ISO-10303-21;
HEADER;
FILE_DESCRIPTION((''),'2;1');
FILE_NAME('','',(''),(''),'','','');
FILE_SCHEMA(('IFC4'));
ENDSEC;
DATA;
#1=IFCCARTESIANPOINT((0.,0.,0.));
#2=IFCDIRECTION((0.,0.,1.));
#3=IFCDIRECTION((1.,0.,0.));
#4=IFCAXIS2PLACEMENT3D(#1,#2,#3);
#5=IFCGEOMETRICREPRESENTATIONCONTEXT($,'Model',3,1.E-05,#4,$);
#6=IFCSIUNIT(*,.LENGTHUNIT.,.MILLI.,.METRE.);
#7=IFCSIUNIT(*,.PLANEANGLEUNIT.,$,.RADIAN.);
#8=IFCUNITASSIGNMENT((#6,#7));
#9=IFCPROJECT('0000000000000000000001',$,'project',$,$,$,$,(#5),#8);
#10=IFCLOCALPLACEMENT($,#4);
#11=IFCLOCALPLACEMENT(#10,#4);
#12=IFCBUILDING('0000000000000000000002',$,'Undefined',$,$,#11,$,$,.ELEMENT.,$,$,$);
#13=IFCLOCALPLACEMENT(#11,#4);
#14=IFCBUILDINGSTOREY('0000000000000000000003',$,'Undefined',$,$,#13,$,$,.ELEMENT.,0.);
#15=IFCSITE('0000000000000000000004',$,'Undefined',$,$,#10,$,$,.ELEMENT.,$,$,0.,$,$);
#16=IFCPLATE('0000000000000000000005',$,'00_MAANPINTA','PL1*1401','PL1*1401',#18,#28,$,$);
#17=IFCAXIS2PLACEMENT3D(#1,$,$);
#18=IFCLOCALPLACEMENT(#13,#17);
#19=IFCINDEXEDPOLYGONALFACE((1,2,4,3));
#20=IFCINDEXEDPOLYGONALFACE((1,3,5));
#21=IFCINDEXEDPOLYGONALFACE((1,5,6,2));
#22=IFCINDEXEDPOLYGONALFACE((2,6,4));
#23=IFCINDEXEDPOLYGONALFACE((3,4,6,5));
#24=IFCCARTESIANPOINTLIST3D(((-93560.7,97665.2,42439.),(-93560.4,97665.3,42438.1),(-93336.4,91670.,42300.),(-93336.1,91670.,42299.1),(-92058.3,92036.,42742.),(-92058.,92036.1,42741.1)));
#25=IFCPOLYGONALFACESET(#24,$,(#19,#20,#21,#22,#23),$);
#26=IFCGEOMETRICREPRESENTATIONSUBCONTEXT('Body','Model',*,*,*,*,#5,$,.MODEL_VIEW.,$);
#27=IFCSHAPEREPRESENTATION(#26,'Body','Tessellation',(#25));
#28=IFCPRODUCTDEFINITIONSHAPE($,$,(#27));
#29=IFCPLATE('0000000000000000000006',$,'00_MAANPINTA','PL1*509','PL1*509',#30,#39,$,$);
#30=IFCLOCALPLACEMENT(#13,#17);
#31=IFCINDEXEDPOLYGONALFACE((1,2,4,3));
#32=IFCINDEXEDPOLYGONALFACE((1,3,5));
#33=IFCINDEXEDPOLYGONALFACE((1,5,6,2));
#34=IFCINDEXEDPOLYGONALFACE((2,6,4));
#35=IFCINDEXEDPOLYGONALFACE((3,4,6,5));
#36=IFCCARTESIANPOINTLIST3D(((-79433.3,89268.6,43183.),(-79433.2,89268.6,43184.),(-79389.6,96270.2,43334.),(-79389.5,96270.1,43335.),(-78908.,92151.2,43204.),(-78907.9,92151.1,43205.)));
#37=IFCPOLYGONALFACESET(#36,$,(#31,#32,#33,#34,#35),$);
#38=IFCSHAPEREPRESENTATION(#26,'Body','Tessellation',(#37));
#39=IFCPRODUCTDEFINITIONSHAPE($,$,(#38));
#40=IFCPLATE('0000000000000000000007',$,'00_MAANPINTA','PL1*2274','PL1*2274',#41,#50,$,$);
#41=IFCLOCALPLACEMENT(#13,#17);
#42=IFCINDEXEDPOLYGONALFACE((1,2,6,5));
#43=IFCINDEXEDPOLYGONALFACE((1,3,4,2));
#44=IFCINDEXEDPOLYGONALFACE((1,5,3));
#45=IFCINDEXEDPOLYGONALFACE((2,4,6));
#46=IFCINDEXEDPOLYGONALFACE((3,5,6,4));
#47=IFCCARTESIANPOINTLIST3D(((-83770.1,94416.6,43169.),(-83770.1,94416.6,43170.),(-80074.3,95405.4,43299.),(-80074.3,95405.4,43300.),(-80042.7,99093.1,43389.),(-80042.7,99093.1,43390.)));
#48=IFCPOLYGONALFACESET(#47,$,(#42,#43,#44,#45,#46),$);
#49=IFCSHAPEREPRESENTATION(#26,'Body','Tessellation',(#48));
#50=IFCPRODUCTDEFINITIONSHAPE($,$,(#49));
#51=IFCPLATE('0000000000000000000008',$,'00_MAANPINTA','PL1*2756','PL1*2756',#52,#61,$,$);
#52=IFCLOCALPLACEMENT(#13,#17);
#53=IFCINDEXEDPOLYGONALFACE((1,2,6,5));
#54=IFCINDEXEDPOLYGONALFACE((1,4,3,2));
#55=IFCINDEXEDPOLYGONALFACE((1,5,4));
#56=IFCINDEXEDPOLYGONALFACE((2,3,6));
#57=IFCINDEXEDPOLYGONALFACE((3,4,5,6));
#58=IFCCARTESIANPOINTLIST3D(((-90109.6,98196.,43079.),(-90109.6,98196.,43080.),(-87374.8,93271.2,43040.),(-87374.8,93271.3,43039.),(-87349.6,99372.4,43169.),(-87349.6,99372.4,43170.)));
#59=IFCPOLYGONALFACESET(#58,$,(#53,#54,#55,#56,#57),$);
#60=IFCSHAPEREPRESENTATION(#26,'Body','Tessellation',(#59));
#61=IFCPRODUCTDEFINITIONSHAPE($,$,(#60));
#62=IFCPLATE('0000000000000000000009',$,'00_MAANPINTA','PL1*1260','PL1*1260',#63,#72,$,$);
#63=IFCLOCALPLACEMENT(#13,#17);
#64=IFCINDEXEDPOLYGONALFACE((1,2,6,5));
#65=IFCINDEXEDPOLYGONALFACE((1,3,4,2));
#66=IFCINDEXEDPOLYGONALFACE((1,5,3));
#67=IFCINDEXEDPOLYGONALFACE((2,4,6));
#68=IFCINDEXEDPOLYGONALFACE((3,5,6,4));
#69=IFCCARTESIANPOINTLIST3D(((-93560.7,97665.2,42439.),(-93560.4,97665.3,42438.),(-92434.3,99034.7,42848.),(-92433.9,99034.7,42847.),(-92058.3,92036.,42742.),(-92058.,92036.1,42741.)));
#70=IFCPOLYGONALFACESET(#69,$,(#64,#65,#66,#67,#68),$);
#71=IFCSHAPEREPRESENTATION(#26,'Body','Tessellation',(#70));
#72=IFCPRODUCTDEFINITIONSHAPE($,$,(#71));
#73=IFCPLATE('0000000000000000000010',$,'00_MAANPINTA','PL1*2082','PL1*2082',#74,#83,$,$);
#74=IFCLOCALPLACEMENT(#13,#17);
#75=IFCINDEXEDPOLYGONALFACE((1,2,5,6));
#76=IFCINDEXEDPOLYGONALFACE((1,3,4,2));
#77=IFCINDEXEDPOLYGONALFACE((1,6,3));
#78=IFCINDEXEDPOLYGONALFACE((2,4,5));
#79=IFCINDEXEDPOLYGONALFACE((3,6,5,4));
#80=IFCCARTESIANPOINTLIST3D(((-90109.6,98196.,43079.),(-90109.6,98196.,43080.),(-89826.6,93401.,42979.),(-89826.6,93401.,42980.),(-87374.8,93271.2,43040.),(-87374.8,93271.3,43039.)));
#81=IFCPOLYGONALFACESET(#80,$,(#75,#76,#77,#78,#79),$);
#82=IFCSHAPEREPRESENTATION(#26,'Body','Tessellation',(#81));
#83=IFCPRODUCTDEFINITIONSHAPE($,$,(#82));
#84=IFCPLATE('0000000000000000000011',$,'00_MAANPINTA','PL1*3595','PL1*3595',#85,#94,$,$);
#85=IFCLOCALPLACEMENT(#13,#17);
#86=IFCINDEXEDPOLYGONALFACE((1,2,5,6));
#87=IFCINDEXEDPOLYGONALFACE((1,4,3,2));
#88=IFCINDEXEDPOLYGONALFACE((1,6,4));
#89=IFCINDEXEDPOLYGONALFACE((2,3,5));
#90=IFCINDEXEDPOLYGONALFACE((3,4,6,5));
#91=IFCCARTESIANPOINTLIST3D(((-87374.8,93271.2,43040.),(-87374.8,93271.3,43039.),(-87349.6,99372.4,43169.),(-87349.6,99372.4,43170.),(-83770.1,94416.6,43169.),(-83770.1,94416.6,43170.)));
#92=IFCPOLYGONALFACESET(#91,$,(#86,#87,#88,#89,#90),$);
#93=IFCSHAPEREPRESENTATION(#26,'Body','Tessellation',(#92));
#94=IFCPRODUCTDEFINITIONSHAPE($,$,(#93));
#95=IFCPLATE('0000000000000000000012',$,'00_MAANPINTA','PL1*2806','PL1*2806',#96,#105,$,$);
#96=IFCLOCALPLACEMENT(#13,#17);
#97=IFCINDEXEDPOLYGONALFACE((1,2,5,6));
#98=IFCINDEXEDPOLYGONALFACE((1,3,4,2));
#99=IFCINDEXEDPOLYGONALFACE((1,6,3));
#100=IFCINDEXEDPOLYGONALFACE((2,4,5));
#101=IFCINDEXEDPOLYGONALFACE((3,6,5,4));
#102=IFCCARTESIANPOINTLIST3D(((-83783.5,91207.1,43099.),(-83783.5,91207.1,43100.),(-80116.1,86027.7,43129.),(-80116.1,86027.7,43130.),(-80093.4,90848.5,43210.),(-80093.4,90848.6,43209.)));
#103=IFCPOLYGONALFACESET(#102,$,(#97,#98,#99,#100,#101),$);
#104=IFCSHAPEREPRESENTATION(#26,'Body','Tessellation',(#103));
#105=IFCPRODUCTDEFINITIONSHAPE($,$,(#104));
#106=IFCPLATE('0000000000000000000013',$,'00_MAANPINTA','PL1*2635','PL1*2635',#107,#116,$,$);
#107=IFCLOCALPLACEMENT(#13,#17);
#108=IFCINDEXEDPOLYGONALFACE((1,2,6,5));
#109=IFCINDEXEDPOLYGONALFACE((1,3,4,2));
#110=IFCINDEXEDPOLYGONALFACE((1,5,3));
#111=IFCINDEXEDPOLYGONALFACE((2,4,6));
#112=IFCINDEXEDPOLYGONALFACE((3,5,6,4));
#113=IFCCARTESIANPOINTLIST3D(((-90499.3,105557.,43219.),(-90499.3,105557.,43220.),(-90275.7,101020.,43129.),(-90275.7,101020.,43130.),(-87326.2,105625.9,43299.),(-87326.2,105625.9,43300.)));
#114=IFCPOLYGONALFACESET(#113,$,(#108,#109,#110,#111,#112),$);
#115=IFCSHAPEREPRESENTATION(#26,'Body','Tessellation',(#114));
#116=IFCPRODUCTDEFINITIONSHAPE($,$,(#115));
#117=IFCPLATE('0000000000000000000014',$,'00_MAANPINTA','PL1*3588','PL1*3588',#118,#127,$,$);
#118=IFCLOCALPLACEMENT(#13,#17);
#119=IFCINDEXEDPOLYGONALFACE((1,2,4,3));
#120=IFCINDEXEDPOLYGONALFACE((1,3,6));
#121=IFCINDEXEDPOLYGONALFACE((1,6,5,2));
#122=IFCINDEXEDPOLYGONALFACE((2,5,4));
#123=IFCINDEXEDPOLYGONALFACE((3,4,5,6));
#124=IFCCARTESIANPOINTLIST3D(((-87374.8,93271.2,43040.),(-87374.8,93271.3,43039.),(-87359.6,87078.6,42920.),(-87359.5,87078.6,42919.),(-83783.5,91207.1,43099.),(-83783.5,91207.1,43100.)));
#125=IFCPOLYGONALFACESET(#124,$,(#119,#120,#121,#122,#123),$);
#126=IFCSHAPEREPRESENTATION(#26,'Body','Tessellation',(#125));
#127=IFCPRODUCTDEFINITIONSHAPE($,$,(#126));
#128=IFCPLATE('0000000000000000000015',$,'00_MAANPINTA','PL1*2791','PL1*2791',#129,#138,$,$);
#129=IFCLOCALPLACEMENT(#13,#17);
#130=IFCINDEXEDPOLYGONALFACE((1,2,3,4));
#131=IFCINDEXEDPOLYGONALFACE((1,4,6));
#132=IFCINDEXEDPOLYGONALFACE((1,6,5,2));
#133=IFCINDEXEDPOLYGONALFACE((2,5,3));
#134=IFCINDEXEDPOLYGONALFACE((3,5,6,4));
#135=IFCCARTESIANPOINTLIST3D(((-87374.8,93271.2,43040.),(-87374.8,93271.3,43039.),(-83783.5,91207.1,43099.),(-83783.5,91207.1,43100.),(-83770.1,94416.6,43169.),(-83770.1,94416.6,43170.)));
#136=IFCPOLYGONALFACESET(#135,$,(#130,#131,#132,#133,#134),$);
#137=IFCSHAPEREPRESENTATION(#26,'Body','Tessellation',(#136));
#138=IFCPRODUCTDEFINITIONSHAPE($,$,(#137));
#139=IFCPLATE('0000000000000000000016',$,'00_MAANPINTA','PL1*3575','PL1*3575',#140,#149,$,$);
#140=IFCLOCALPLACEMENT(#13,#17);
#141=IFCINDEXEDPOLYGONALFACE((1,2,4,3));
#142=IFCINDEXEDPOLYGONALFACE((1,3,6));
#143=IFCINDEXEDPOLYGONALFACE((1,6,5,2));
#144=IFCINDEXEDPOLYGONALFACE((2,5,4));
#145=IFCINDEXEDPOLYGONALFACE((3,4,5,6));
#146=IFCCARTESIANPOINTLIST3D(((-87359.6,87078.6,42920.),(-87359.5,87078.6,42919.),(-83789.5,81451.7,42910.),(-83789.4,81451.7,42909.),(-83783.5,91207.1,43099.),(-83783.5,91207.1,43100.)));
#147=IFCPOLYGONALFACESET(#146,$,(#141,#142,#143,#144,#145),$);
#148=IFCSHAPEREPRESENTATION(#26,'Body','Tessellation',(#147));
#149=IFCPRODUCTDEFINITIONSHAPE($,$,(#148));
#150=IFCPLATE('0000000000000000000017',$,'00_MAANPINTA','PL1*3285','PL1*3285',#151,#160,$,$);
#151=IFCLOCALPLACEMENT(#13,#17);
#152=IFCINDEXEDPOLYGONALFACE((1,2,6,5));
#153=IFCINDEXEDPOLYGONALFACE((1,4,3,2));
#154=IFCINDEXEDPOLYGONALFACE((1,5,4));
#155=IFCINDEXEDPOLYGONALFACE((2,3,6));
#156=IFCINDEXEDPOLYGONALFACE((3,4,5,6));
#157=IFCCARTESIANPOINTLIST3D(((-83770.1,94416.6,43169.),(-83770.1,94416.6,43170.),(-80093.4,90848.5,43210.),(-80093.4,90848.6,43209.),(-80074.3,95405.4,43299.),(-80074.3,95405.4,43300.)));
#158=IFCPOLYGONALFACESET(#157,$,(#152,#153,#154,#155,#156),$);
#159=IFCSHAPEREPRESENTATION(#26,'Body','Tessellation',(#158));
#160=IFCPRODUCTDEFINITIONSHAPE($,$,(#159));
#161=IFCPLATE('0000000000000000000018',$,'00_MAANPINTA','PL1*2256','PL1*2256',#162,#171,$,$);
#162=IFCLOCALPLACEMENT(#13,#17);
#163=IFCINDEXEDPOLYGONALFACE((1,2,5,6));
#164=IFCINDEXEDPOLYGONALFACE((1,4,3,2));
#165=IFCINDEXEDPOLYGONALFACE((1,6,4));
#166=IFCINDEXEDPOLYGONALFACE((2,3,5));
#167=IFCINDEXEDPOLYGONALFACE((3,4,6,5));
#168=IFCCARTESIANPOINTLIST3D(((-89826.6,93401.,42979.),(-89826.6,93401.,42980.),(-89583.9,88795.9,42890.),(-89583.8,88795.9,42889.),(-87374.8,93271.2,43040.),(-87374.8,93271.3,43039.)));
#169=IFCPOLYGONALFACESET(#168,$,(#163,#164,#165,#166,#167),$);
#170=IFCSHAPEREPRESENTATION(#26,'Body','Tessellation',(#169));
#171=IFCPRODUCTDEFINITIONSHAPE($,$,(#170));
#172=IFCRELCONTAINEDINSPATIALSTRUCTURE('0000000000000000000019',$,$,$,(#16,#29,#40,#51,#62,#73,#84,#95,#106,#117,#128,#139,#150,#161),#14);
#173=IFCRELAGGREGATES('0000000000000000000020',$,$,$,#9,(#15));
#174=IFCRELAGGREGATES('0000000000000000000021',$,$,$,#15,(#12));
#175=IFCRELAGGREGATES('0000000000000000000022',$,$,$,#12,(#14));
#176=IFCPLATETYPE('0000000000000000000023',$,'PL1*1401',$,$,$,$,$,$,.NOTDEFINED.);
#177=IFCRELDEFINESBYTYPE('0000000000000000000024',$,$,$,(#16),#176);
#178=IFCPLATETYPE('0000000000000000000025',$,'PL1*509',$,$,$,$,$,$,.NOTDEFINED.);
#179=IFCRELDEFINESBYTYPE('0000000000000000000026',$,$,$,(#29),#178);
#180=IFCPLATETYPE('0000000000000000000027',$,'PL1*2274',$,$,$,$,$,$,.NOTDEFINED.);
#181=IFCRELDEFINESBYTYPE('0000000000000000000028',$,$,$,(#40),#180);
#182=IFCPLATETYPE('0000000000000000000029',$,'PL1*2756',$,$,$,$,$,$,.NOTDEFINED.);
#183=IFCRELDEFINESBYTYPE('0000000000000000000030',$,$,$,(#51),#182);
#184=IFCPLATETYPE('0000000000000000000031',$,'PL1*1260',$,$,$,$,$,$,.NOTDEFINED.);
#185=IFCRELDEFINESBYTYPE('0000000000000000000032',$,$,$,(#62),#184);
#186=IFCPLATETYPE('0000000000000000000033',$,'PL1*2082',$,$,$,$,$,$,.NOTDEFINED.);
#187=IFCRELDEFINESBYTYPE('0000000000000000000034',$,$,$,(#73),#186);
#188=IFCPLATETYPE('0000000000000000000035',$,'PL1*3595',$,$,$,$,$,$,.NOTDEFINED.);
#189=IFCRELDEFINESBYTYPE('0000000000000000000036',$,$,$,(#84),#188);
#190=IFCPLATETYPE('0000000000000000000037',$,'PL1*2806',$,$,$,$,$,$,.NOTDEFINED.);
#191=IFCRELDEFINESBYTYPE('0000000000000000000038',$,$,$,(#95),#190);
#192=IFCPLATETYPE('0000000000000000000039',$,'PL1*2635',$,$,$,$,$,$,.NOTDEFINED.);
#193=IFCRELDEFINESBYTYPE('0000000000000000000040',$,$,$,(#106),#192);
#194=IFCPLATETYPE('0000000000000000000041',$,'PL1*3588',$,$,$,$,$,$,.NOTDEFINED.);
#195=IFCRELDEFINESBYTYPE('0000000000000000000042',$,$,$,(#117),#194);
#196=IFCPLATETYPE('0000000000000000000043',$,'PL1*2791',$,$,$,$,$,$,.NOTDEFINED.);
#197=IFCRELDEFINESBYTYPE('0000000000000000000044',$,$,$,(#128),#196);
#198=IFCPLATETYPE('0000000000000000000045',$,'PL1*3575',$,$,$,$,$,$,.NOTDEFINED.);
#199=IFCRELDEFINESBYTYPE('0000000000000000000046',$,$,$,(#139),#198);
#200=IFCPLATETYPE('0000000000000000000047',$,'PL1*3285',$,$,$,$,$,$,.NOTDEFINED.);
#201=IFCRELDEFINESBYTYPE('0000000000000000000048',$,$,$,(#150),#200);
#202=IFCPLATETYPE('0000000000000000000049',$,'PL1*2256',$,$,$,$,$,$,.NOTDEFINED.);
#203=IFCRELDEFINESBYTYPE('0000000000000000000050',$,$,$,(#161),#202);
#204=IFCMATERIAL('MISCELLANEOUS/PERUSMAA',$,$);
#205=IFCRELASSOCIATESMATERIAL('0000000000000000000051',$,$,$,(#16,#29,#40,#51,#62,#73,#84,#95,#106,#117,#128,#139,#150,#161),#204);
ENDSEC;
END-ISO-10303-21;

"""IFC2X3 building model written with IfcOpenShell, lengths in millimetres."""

from ifc_helpers import new_model, si_unit, frame, origin_with_axes, place, context, subcontext, project, spatial, polyline, outline, extrude, material, type_object, element, save


model = new_model("IFC2X3")

# Units and contexts
model_context = context("Model", 3, precision=1e-05, world=origin_with_axes())
body_context = subcontext(model_context, "Body", "Model", "MODEL_VIEW")
ifc_project = project(units=[si_unit("LENGTHUNIT", "METRE", prefix="MILLI"), si_unit("PLANEANGLEUNIT", "RADIAN")], contexts=[model_context])

# Site, building, storey
site_placement = place(None, origin_with_axes())
site = spatial("IfcSite", under=ifc_project, at=site_placement, Name="Undefined", CompositionType="ELEMENT", RefElevation=0.0)
building_placement = place(site_placement, origin_with_axes())
building = spatial("IfcBuilding", under=site, at=building_placement, Name="Undefined", CompositionType="ELEMENT")
storey_placement = place(building_placement, origin_with_axes())
storey = spatial("IfcBuildingStorey", under=building, at=storey_placement, Name="Undefined", CompositionType="ELEMENT", Elevation=0.0)

# Plates
ifc_material = material(Name="MISCELLANEOUS/PERUSMAA")
plate_type_1 = type_object("IfcPlateType", Name="PL1*1401", PredefinedType="NOTDEFINED")
plate_1_placement = place(storey_placement, frame((-92058.1, 92036.1, 42741.5), z_axis=(0.317963, 0.033864, -0.947498), x_axis=(-0.912256, -0.261275, -0.315475)))
element("IfcPlate", 1, at=plate_1_placement, inside=storey, type_object=plate_type_1, material=ifc_material, Name="00_MAANPINTA", Description="PL1*1401", ObjectType="PL1*1401", context=body_context, shape_type="SweptSolid", body=[
    extrude(outline(polyline([(0.0, 0.0), (1401.1, 0.0), (-4.6, 5834.1), (0.0, 0.0)])), frame((0.0, 0.0, -0.5), z_axis=(0.0, 0.0, 1.0), x_axis=(1.0, 0.0, 0.0)), (0.0, 0.0, 1.0), 1.0),
])
plate_type_2 = type_object("IfcPlateType", Name="PL1*509", PredefinedType="NOTDEFINED")
plate_2_placement = place(storey_placement, frame((-79433.3, 89268.6, 43183.5), z_axis=(-0.08086, 0.021995, -0.996483), x_axis=(0.00624, 0.999748, 0.021561)))
element("IfcPlate", 2, at=plate_2_placement, inside=storey, type_object=plate_type_2, material=ifc_material, Name="00_MAANPINTA", Description="PL1*509", ObjectType="PL1*509", context=body_context, shape_type="SweptSolid", body=[
    extrude(outline(polyline([(0.0, 0.0), (7003.3, 0.0), (2885.6, 509.0), (0.0, 0.0)])), frame((0.0, 0.0, -0.5), z_axis=(0.0, 0.0, 1.0), x_axis=(1.0, 0.0, 0.0)), (0.0, 0.0, 1.0), 1.0),
])
plate_type_3 = type_object("IfcPlateType", Name="PL1*2274", PredefinedType="NOTDEFINED")
plate_3_placement = place(storey_placement, frame((-80042.7, 99093.1, 43389.5), z_axis=(0.028691, 0.024142, -0.999297), x_axis=(-0.008568, -0.999666, -0.024397)))
element("IfcPlate", 3, at=plate_3_placement, inside=storey, type_object=plate_type_3, material=ifc_material, Name="00_MAANPINTA", Description="PL1*2274", ObjectType="PL1*2274", context=body_context, shape_type="SweptSolid", body=[
    extrude(outline(polyline([(0.0, 0.0), (3688.9, 0.0), (4712.2, 3688.7), (0.0, 0.0)])), frame((0.0, 0.0, -0.5), z_axis=(0.0, 0.0, 1.0), x_axis=(1.0, 0.0, 0.0)), (0.0, 0.0, 1.0), 1.0),
])
plate_type_4 = type_object("IfcPlateType", Name="PL1*2756", PredefinedType="NOTDEFINED")
plate_4_placement = place(storey_placement, frame((-90109.6, 98196.0, 43079.5), z_axis=(0.023556, 0.021199, -0.999498), x_axis=(0.919503, 0.391938, 0.029984)))
element("IfcPlate", 4, at=plate_4_placement, inside=storey, type_object=plate_type_4, material=ifc_material, Name="00_MAANPINTA", Description="PL1*2756", ObjectType="PL1*2756", context=body_context, shape_type="SweptSolid", body=[
    extrude(outline(polyline([(0.0, 0.0), (3001.6, 0.0), (583.3, 5603.0), (0.0, 0.0)])), frame((0.0, 0.0, -0.5), z_axis=(0.0, 0.0, 1.0), x_axis=(1.0, 0.0, 0.0)), (0.0, 0.0, 1.0), 1.0),
])
plate_type_5 = type_object("IfcPlateType", Name="PL1*1260", PredefinedType="NOTDEFINED")
plate_5_placement = place(storey_placement, frame((-92058.1, 92036.0, 42741.5), z_axis=(0.307681, 0.030931, -0.950987), x_axis=(-0.257524, 0.964875, -0.051936)))
element("IfcPlate", 5, at=plate_5_placement, inside=storey, type_object=plate_type_5, material=ifc_material, Name="00_MAANPINTA", Description="PL1*1260", ObjectType="PL1*1260", context=body_context, shape_type="SweptSolid", body=[
    extrude(outline(polyline([(0.0, 0.0), (5834.1, 0.0), (6844.1, 1513.8), (0.0, 0.0)])), frame((0.0, 0.0, -0.5), z_axis=(0.0, 0.0, 1.0), x_axis=(1.0, 0.0, 0.0)), (0.0, 0.0, 1.0), 1.0),
])
plate_type_6 = type_object("IfcPlateType", Name="PL1*2082", PredefinedType="NOTDEFINED")
plate_6_placement = place(storey_placement, frame((-90109.6, 98196.0, 43079.5), z_axis=(0.02564, 0.022356, -0.999421), x_axis=(0.485475, -0.874221, -0.007101)))
element("IfcPlate", 6, at=plate_6_placement, inside=storey, type_object=plate_type_6, material=ifc_material, Name="00_MAANPINTA", Description="PL1*2082", ObjectType="PL1*2082", context=body_context, shape_type="SweptSolid", body=[
    extrude(outline(polyline([(0.0, 0.0), (5633.3, 0.0), (4330.0, 2081.7), (0.0, 0.0)])), frame((0.0, 0.0, -0.5), z_axis=(0.0, 0.0, 1.0), x_axis=(1.0, 0.0, 0.0)), (0.0, 0.0, 1.0), 1.0),
])
plate_type_7 = type_object("IfcPlateType", Name="PL1*3595", PredefinedType="NOTDEFINED")
plate_7_placement = place(storey_placement, frame((-87349.6, 99372.4, 43169.5), z_axis=(0.029313, 0.021172, -0.999346), x_axis=(0.585524, -0.810655, 0.0)))
element("IfcPlate", 7, at=plate_7_placement, inside=storey, type_object=plate_type_7, material=ifc_material, Name="00_MAANPINTA", Description="PL1*3595", ObjectType="PL1*3595", context=body_context, shape_type="SweptSolid", body=[
    extrude(outline(polyline([(0.0, 0.0), (6113.4, 0.0), (4931.2, 3595.1), (0.0, 0.0)])), frame((0.0, 0.0, -0.5), z_axis=(0.0, 0.0, 1.0), x_axis=(1.0, 0.0, 0.0)), (0.0, 0.0, 1.0), 1.0),
])
plate_type_8 = type_object("IfcPlateType", Name="PL1*2806", PredefinedType="NOTDEFINED")
plate_8_placement = place(storey_placement, frame((-83783.5, 91207.1, 43099.5), z_axis=(0.031388, 0.016437, -0.999372), x_axis=(0.994875, -0.096669, 0.029657)))
element("IfcPlate", 8, at=plate_8_placement, inside=storey, type_object=plate_type_8, material=ifc_material, Name="00_MAANPINTA", Description="PL1*2806", ObjectType="PL1*2806", context=body_context, shape_type="SweptSolid", body=[
    extrude(outline(polyline([(0.0, 0.0), (3709.1, 0.0), (4150.2, 4801.3), (0.0, 0.0)])), frame((0.0, 0.0, -0.5), z_axis=(0.0, 0.0, 1.0), x_axis=(1.0, 0.0, 0.0)), (0.0, 0.0, 1.0), 1.0),
])
plate_type_9 = type_object("IfcPlateType", Name="PL1*2635", PredefinedType="NOTDEFINED")
plate_9_placement = place(storey_placement, frame((-90275.7, 101020.0, 43129.5), z_axis=(0.024742, 0.021046, -0.999472), x_axis=(-0.049216, 0.998592, 0.019809)))
element("IfcPlate", 9, at=plate_9_placement, inside=storey, type_object=plate_type_9, material=ifc_material, Name="00_MAANPINTA", Description="PL1*2635", ObjectType="PL1*2635", context=body_context, shape_type="SweptSolid", body=[
    extrude(outline(polyline([(0.0, 0.0), (4543.4, 0.0), (4457.6, 3173.7), (0.0, 0.0)])), frame((0.0, 0.0, -0.5), z_axis=(0.0, 0.0, 1.0), x_axis=(1.0, 0.0, 0.0)), (0.0, 0.0, 1.0), 1.0),
])
plate_type_10 = type_object("IfcPlateType", Name="PL1*3588", PredefinedType="NOTDEFINED")
plate_10_placement = place(storey_placement, frame((-87374.8, 93271.3, 43039.5), z_axis=(0.027868, 0.019435, -0.999423), x_axis=(0.866904, -0.498265, 0.014483)))
element("IfcPlate", 10, at=plate_10_placement, inside=storey, type_object=plate_type_10, material=ifc_material, Name="00_MAANPINTA", Description="PL1*3588", ObjectType="PL1*3588", context=body_context, shape_type="SweptSolid", body=[
    extrude(outline(polyline([(0.0, 0.0), (4142.7, 0.0), (3097.1, 5363.9), (0.0, 0.0)])), frame((0.0, 0.0, -0.5), z_axis=(0.0, 0.0, 1.0), x_axis=(1.0, 0.0, 0.0)), (0.0, 0.0, 1.0), 1.0),
])
plate_type_11 = type_object("IfcPlateType", Name="PL1*2791", PredefinedType="NOTDEFINED")
plate_11_placement = place(storey_placement, frame((-83770.1, 94416.6, 43169.5), z_axis=(0.029154, 0.021674, -0.99934), x_axis=(-0.004177, -0.999754, -0.021805)))
element("IfcPlate", 11, at=plate_11_placement, inside=storey, type_object=plate_type_11, material=ifc_material, Name="00_MAANPINTA", Description="PL1*2791", ObjectType="PL1*2791", context=body_context, shape_type="SweptSolid", body=[
    extrude(outline(polyline([(0.0, 0.0), (3210.3, 0.0), (1163.0, 3601.4), (0.0, 0.0)])), frame((0.0, 0.0, -0.5), z_axis=(0.0, 0.0, 1.0), x_axis=(1.0, 0.0, 0.0)), (0.0, 0.0, 1.0), 1.0),
])
plate_type_12 = type_object("IfcPlateType", Name="PL1*3575", PredefinedType="NOTDEFINED")
plate_12_placement = place(storey_placement, frame((-83783.5, 91207.1, 43099.5), z_axis=(0.027853, 0.019448, -0.999423), x_axis=(-0.00061, -0.99981, -0.019473)))
element("IfcPlate", 12, at=plate_12_placement, inside=storey, type_object=plate_type_12, material=ifc_material, Name="00_MAANPINTA", Description="PL1*3575", ObjectType="PL1*3575", context=body_context, shape_type="SweptSolid", body=[
    extrude(outline(polyline([(0.0, 0.0), (9757.3, 0.0), (4133.4, 3574.9), (0.0, 0.0)])), frame((0.0, 0.0, -0.5), z_axis=(0.0, 0.0, 1.0), x_axis=(1.0, 0.0, 0.0)), (0.0, 0.0, 1.0), 1.0),
])
plate_type_13 = type_object("IfcPlateType", Name="PL1*3285", PredefinedType="NOTDEFINED")
plate_13_placement = place(storey_placement, frame((-80074.3, 95405.4, 43299.5), z_axis=(0.029905, 0.019613, -0.99936), x_axis=(-0.004191, -0.999796, -0.019746)))
element("IfcPlate", 13, at=plate_13_placement, inside=storey, type_object=plate_type_13, material=ifc_material, Name="00_MAANPINTA", Description="PL1*3285", ObjectType="PL1*3285", context=body_context, shape_type="SweptSolid", body=[
    extrude(outline(polyline([(0.0, 0.0), (4557.8, 0.0), (1006.7, 3693.2), (0.0, 0.0)])), frame((0.0, 0.0, -0.5), z_axis=(0.0, 0.0, 1.0), x_axis=(1.0, 0.0, 0.0)), (0.0, 0.0, 1.0), 1.0),
])
plate_type_14 = type_object("IfcPlateType", Name="PL1*2256", PredefinedType="NOTDEFINED")
plate_14_placement = place(storey_placement, frame((-89826.6, 93401.0, 42979.5), z_axis=(0.025563, 0.020881, -0.999455), x_axis=(0.998306, -0.052811, 0.02443)))
element("IfcPlate", 14, at=plate_14_placement, inside=storey, type_object=plate_type_14, material=ifc_material, Name="00_MAANPINTA", Description="PL1*2256", ObjectType="PL1*2256", context=body_context, shape_type="SweptSolid", body=[
    extrude(outline(polyline([(0.0, 0.0), (2456.0, 0.0), (483.4, 4587.0), (0.0, 0.0)])), frame((0.0, 0.0, -0.5), z_axis=(0.0, 0.0, 1.0), x_axis=(1.0, 0.0, 0.0)), (0.0, 0.0, 1.0), 1.0),
])

save(model, "model.ifc")
